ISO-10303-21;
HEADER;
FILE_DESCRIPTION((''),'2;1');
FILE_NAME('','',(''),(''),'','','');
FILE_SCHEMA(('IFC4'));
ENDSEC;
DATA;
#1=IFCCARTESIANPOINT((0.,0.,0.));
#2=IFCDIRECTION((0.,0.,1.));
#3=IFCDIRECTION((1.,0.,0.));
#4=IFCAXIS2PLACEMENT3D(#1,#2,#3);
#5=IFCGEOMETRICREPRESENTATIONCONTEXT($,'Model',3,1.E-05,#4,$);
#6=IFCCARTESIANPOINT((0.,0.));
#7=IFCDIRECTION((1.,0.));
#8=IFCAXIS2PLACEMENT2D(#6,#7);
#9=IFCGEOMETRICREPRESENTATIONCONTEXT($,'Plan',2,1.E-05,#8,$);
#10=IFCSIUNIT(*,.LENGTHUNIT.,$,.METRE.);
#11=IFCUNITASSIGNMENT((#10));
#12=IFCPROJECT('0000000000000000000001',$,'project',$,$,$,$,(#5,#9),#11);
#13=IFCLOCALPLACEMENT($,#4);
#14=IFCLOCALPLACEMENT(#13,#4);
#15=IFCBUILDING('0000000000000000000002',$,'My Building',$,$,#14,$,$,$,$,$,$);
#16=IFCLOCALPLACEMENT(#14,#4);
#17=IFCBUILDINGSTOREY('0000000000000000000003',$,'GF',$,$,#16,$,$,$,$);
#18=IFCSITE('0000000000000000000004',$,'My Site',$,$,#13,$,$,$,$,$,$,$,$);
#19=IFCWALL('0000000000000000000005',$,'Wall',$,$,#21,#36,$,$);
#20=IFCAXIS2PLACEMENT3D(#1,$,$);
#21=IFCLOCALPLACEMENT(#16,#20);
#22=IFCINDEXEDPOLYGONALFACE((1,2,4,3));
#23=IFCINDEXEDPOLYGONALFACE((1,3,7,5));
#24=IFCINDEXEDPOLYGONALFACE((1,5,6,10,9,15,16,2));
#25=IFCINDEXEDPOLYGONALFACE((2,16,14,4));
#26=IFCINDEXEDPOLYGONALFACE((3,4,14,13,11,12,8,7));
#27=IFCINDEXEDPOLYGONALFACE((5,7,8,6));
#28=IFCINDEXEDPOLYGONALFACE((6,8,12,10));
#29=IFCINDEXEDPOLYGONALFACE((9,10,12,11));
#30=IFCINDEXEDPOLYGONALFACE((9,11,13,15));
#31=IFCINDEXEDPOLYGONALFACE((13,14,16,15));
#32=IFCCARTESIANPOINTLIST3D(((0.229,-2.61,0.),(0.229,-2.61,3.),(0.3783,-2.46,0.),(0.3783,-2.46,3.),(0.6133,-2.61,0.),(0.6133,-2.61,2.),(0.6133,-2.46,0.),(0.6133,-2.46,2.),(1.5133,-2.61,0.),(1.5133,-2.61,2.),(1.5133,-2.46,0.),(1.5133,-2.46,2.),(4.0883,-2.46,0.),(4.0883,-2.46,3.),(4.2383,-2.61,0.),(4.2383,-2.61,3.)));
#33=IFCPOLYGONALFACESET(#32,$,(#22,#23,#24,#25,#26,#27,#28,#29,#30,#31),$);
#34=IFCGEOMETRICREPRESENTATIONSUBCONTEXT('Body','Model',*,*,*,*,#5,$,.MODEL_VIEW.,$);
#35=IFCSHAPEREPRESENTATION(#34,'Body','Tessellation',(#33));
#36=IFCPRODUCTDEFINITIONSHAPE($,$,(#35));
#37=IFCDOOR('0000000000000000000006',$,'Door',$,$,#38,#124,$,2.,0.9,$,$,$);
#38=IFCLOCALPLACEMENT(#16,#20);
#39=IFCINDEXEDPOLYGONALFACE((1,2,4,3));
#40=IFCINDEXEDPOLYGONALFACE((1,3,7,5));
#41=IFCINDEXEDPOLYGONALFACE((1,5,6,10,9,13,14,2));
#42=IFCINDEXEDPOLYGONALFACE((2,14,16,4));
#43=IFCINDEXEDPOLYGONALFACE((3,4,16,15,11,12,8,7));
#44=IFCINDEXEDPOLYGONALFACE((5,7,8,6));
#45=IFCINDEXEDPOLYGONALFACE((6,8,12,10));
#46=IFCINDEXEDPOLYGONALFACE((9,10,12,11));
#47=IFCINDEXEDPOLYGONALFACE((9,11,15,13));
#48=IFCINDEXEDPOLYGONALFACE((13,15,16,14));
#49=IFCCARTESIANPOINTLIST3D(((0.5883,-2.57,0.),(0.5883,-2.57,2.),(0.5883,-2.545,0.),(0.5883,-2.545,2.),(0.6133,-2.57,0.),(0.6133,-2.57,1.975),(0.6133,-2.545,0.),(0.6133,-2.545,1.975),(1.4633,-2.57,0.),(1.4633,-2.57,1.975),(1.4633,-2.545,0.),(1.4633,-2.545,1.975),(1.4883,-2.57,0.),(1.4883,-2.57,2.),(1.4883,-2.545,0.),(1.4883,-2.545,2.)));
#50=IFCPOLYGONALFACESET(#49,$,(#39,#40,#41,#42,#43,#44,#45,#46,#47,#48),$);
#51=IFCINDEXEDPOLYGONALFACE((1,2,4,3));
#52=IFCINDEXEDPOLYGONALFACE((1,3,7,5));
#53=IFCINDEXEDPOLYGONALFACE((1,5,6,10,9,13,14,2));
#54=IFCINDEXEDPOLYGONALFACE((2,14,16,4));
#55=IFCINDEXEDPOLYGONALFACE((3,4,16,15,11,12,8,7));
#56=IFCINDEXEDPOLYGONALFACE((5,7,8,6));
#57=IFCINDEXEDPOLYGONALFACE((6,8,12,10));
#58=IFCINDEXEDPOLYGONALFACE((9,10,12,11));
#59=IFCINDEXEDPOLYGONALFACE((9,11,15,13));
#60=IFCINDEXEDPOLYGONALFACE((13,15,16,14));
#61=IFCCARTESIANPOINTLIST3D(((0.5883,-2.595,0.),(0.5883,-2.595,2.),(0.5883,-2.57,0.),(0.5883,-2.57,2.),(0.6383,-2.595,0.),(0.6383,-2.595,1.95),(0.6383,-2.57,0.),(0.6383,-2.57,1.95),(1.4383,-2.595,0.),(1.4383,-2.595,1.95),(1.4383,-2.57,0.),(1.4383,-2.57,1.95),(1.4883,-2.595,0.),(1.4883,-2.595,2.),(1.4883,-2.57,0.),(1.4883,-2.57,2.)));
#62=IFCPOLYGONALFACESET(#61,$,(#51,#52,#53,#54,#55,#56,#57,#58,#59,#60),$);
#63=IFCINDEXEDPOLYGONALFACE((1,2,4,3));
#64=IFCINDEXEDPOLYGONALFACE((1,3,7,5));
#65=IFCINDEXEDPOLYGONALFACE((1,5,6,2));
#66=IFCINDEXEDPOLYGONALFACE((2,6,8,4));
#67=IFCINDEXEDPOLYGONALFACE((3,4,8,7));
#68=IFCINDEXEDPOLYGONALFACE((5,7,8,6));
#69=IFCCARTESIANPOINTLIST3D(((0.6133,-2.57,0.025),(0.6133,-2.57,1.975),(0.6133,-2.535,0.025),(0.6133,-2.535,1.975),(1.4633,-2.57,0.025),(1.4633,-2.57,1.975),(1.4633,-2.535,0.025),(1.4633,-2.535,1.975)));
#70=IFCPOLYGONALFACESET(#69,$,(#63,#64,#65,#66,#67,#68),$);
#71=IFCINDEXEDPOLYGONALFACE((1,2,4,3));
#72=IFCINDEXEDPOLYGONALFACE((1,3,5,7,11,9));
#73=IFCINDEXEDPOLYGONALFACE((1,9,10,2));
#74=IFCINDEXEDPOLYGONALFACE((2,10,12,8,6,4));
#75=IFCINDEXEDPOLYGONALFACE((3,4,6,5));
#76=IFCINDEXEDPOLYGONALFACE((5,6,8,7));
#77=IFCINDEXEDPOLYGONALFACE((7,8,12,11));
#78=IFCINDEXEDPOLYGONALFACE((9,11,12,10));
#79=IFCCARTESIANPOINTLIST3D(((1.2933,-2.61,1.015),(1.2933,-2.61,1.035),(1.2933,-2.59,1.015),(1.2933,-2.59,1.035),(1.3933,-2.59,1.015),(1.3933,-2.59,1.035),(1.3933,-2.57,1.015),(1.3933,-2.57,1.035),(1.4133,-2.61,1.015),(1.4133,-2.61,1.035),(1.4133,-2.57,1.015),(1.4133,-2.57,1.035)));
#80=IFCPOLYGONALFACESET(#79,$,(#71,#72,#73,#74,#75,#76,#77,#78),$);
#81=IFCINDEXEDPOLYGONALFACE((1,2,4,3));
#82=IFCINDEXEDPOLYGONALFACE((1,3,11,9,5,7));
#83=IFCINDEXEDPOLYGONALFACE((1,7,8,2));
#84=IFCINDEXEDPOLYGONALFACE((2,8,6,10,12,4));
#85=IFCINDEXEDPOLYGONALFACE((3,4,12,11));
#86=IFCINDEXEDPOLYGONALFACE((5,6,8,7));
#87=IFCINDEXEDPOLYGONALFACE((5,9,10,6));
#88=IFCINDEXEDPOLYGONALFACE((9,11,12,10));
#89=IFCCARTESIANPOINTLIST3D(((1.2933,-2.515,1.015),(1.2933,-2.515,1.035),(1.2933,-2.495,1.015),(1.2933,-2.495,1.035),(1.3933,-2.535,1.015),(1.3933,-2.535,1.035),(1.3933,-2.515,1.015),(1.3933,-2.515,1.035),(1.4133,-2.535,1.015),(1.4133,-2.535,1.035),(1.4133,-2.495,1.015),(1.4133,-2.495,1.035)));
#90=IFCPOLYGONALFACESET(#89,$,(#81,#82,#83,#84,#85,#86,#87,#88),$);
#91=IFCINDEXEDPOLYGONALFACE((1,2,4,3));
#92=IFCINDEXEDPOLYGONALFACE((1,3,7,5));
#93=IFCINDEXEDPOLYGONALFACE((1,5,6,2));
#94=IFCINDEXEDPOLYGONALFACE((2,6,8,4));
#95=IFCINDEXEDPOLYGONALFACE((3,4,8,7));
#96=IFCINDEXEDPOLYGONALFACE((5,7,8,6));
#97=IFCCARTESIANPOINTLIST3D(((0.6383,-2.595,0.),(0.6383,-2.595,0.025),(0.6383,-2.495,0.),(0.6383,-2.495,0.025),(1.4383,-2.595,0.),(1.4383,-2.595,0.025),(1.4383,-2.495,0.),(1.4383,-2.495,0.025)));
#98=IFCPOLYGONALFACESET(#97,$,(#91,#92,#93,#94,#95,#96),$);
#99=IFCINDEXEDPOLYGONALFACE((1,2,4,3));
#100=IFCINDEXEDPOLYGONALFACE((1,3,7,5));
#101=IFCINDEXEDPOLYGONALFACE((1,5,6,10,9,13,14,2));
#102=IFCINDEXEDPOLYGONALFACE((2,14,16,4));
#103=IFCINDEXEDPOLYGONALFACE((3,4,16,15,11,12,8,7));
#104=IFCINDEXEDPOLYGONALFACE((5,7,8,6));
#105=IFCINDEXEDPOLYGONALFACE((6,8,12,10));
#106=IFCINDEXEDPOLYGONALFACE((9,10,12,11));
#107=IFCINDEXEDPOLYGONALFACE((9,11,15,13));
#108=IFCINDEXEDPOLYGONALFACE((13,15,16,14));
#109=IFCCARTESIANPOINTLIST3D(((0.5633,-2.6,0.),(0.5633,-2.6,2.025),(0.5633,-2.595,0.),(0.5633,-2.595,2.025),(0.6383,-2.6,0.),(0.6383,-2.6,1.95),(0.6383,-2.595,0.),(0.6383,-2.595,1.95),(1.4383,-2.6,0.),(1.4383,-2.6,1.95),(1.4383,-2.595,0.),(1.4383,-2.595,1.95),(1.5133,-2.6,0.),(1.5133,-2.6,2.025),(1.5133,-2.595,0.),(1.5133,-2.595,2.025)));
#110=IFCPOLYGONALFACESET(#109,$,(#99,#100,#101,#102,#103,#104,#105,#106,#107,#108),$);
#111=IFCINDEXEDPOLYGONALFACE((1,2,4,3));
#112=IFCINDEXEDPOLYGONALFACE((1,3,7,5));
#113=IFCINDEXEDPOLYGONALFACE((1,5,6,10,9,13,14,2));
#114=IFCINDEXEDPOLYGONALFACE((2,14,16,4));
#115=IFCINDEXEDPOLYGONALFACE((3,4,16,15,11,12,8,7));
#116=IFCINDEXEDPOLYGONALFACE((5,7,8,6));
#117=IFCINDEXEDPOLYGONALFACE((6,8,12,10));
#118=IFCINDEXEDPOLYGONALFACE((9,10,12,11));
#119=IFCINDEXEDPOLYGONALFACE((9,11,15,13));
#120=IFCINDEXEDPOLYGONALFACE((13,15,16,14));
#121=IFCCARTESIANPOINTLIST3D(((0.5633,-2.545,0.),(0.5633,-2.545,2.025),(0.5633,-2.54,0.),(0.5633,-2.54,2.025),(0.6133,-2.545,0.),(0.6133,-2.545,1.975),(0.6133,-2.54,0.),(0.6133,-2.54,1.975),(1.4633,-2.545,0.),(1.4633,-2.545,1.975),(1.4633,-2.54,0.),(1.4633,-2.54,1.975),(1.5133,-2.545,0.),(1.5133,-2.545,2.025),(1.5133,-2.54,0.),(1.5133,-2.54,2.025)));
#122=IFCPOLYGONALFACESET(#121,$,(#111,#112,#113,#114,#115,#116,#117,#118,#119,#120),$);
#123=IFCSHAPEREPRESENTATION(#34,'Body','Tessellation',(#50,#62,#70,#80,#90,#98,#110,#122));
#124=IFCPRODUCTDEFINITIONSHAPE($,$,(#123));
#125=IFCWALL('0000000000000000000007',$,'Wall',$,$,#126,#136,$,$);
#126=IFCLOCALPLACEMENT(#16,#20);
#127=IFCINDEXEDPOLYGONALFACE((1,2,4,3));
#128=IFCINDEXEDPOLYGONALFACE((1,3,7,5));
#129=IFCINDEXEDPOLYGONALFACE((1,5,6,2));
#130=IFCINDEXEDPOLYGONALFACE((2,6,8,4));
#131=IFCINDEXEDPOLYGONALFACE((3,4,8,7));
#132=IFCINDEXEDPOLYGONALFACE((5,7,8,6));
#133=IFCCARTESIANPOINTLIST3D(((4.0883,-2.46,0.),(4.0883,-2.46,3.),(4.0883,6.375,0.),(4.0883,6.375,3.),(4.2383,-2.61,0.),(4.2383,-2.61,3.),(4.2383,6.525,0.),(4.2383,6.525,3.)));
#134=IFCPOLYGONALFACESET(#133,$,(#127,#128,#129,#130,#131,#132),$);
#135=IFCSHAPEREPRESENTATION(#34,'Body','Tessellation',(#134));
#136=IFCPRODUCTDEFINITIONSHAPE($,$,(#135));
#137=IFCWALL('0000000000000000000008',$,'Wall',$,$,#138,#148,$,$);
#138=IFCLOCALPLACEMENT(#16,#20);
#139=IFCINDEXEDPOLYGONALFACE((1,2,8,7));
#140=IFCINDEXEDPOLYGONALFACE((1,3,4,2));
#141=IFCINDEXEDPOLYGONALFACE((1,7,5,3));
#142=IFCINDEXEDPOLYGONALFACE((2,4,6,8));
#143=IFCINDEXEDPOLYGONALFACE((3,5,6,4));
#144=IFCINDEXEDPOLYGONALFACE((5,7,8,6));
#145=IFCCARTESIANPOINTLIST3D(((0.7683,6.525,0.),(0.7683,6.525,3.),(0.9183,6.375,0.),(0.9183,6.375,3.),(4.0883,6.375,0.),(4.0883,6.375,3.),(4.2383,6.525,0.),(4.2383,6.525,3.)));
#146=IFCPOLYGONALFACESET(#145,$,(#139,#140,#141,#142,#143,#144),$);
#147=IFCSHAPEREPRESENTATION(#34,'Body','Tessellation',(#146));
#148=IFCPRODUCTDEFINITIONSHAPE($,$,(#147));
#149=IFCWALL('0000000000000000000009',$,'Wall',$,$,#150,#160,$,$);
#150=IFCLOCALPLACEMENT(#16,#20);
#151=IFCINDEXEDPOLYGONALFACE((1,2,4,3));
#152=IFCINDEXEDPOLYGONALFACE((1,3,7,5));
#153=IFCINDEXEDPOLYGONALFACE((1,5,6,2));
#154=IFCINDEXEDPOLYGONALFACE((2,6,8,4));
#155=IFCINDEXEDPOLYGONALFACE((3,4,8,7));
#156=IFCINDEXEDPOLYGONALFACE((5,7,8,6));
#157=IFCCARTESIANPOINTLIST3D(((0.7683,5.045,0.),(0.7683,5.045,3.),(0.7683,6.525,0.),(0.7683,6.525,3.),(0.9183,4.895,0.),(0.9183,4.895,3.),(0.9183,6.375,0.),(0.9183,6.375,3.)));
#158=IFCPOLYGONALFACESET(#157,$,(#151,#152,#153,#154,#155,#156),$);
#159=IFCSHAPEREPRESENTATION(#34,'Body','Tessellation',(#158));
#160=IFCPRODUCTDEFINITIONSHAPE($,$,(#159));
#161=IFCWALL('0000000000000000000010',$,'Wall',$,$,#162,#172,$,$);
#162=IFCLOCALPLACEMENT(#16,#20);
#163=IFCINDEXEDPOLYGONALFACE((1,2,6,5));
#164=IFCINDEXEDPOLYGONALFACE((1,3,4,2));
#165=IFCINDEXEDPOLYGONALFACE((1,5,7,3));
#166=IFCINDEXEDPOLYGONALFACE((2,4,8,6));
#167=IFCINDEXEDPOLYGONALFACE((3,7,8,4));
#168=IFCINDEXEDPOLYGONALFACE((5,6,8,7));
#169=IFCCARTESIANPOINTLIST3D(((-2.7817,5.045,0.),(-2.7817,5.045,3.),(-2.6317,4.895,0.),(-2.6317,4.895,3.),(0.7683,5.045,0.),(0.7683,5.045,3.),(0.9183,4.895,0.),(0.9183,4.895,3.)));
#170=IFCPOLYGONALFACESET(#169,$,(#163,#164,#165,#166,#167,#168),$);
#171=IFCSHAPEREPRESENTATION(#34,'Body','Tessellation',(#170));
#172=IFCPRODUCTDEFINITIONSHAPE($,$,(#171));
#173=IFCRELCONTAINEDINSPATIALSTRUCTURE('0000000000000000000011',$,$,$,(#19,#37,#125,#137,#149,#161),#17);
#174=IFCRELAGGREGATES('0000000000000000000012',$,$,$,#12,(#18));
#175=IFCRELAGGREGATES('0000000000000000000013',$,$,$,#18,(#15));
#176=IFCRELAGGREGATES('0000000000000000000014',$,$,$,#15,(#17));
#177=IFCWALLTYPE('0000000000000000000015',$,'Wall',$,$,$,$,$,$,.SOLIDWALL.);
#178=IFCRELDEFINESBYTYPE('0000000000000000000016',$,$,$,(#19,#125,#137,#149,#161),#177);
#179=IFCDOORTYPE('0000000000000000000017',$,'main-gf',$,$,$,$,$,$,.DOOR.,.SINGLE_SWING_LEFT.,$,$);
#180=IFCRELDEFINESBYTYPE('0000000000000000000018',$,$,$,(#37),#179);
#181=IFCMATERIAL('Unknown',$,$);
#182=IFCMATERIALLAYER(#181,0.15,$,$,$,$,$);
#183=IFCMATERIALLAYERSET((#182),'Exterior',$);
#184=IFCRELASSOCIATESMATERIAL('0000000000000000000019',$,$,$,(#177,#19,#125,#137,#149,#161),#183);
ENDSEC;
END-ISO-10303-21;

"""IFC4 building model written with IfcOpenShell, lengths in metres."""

from ifc_helpers import new_model, entity, si_unit, frame, origin_with_axes, origin_2d_with_axis, place, context, subcontext, project, spatial, line, indexed_curve, outline, extrude, shape, source, transform, mapped, material, layer, layer_set, layer_usage, type_object, type_shapes, element, fill, save


model = new_model("IFC4")

# Units and contexts
model_context = context("Model", 3, precision=1e-05, world=origin_with_axes())
plan_context = context("Plan", 2, precision=1e-05, world=origin_2d_with_axis())
body_context_1 = subcontext(model_context, "Body", "Model", "MODEL_VIEW")
body_context_2 = subcontext(plan_context, "Body", "Plan", "PLAN_VIEW")
ifc_project = project(units=[si_unit("LENGTHUNIT", "METRE")], contexts=[model_context, plan_context])

# Site, building, storey
site_placement = place(None, origin_with_axes())
site = spatial("IfcSite", under=ifc_project, at=site_placement, Name="My Site")
building_placement = place(site_placement, origin_with_axes())
building = spatial("IfcBuilding", under=site, at=building_placement, Name="My Building")
storey_placement = place(building_placement, origin_with_axes())
storey = spatial("IfcBuildingStorey", under=building, at=storey_placement, Name="GF")

# Wall, opening, door
ifc_material = material(Name="Unknown")
ifc_layer_1 = layer(ifc_material, 0.15)
ifc_layer_set_1 = layer_set([ifc_layer_1], Name="Exterior")
ifc_layer_usage_1 = layer_usage(ifc_layer_set_1, "AXIS2", "POSITIVE", 0.0)
wall_type_1 = type_object("IfcWallType", Name="Wall", PredefinedType="SOLIDWALL", material=ifc_layer_set_1)
wall_1_placement = place(storey_placement, frame((0.229, -2.61, 0.0), z_axis=(0.0, 0.0, 1.0), x_axis=(1.0, 0.0, 0.0)))
wall_1 = element("IfcWall", 1, at=wall_1_placement, inside=storey, type_object=wall_type_1, material=ifc_layer_usage_1, Name="Wall", context=body_context_1, shape_type="SweptSolid", body=[
    extrude(outline(indexed_curve([(0.0, 0.0), (0.1494, 0.15), (3.8594, 0.15), (4.0094, 0.0)], segments=[line(1, 2, 3, 4, 1)])), origin_with_axes(), (0.0, 0.0, 1.0), 3.0),
])
shared_shape_1 = source(origin_with_axes(), body_context_1, "Body", "SweptSolid", [
    extrude(outline(indexed_curve([(0.0, 0.0), (0.9, 0.0), (0.9, 2.0), (0.0, 2.0)], segments=[line(1, 2, 3, 4, 1)])), frame((0.0, -0.6, 0.0), z_axis=(0.0, -1.0, 0.0), x_axis=(1.0, 0.0, 0.0)), (0.0, 0.0, -1.0), 1.2),
])
opening_placement = place(wall_1_placement, frame((1.2843, 0.15, 0.0), z_axis=(0.0, 0.0, 1.0), x_axis=(-1.0, 0.0, 0.0)))
opening = element("IfcOpeningElement", 2, at=opening_placement, cuts=wall_1, PredefinedType="OPENING", context=body_context_1, shape_type="MappedRepresentation", body=[
    mapped(shared_shape_1, transform((0.0, 0.0, 0.0), x_axis=(1.0, 0.0, 0.0), y_axis=(0.0, 1.0, 0.0), z_axis=(0.0, 0.0, 1.0), scale=1.0)),
])
door_type = type_object("IfcDoorType", Name="main-gf", OperationType="SINGLE_SWING_LEFT", PredefinedType="DOOR")
shared_shape_2 = source(origin_with_axes(), body_context_1, "Body", "SweptSolid", [
    extrude(outline(indexed_curve([(0.0, 0.0), (0.0, 2.0), (0.9, 2.0), (0.9, 0.0), (0.875, 0.0), (0.875, 1.975), (0.025, 1.975), (0.025, 0.0)], segments=[line(1, 2, 3, 4, 5, 6, 7, 8, 1)])), frame((0.0, 0.025, 0.0), z_axis=(0.0, -1.0, 0.0), x_axis=(1.0, 0.0, 0.0)), (0.0, 0.0, -1.0), 0.025),
    extrude(outline(indexed_curve([(0.0, 0.0), (0.0, 2.0), (0.9, 2.0), (0.9, 0.0), (0.85, 0.0), (0.85, 1.95), (0.05, 1.95), (0.05, 0.0)], segments=[line(1, 2, 3, 4, 5, 6, 7, 8, 1)])), frame((0.0, 0.0, 0.0), z_axis=(0.0, -1.0, 0.0), x_axis=(1.0, 0.0, 0.0)), (0.0, 0.0, -1.0), 0.025),
    extrude(outline(indexed_curve([(0.0, 0.0), (0.85, 0.0), (0.85, 0.035), (0.0, 0.035)], segments=[line(1, 2, 3, 4, 1)])), frame((0.025, 0.025, 0.025), z_axis=(0.0, 0.0, 1.0), x_axis=(1.0, 0.0, 0.0)), (0.0, 0.0, 1.0), 1.95),
    extrude(outline(indexed_curve([(0.0, 0.0), (0.0, -0.04), (-0.12, -0.04), (-0.12, -0.02), (-0.02, -0.02), (-0.02, 0.0)], segments=[line(1, 2, 3, 4, 5, 6, 1)])), frame((0.825, 0.025, 1.015), z_axis=(0.0, 0.0, 1.0), x_axis=(1.0, 0.0, 0.0)), (0.0, 0.0, 1.0), 0.02),
    extrude(outline(indexed_curve([(0.0, 0.0), (0.0, 0.04), (-0.12, 0.04), (-0.12, 0.02), (-0.02, 0.02), (-0.02, 0.0)], segments=[line(1, 2, 3, 4, 5, 6, 1)])), frame((0.825, 0.06, 1.015), z_axis=(0.0, 0.0, 1.0), x_axis=(1.0, 0.0, 0.0)), (0.0, 0.0, 1.0), 0.02),
    extrude(outline(indexed_curve([(0.0, 0.0), (0.8, 0.0), (0.8, 0.1), (0.0, 0.1)], segments=[line(1, 2, 3, 4, 1)])), frame((0.05, 0.0, 0.0), z_axis=(0.0, 0.0, 1.0), x_axis=(1.0, 0.0, 0.0)), (0.0, 0.0, 1.0), 0.025),
    extrude(outline(indexed_curve([(0.0, 0.0), (0.0, 2.025), (0.95, 2.025), (0.95, 0.0), (0.875, 0.0), (0.875, 1.95), (0.075, 1.95), (0.075, 0.0)], segments=[line(1, 2, 3, 4, 5, 6, 7, 8, 1)])), frame((-0.025, -0.005, 0.0), z_axis=(0.0, -1.0, 0.0), x_axis=(1.0, 0.0, 0.0)), (0.0, 0.0, -1.0), 0.005),
    extrude(outline(indexed_curve([(0.0, 0.0), (0.0, 2.025), (0.95, 2.025), (0.95, 0.0), (0.9, 0.0), (0.9, 1.975), (0.05, 1.975), (0.05, 0.0)], segments=[line(1, 2, 3, 4, 5, 6, 7, 8, 1)])), frame((-0.025, 0.05, 0.0), z_axis=(0.0, -1.0, 0.0), x_axis=(1.0, 0.0, 0.0)), (0.0, 0.0, -1.0), 0.005),
])
shared_shape_3 = source(origin_with_axes(), body_context_2, "Body", "Curve2D", [
    entity("IfcIndexedPolyCurve", entity("IfcCartesianPointList2D", [[0.0, 0.0], [0.0, 0.05], [0.025, 0.05], [0.025, 0.025], [0.05, 0.025], [0.05, 0.0]]), [entity("IfcLineIndex", [1, 2, 3, 4, 5, 6, 1])]),
    entity("IfcIndexedPolyCurve", entity("IfcCartesianPointList2D", [[0.9, 0.0], [0.9, 0.05], [0.875, 0.05], [0.875, 0.025], [0.85, 0.025], [0.85, 0.0]]), [entity("IfcLineIndex", [1, 2, 3, 4, 5, 6, 1])]),
    entity("IfcTrimmedCurve", entity("IfcEllipse", entity("IfcAxis2Placement2D", entity("IfcCartesianPoint", [0.06, 0.05]), entity("IfcDirection", [1.0, 0.0])), 0.815, 0.85), [entity("IfcCartesianPoint", [0.875, 0.05])], [entity("IfcCartesianPoint", [0.06, 0.9])], True, "CARTESIAN"),
    entity("IfcIndexedPolyCurve", entity("IfcCartesianPointList2D", [[0.025, 0.05], [0.06, 0.05], [0.06, 0.9], [0.025, 0.9]]), [entity("IfcLineIndex", [1, 2, 3, 4, 1])]),
])
type_shapes(door_type, [shared_shape_2, shared_shape_3])
door_placement = place(opening_placement, frame((0.925, 0.135, 0.0), z_axis=(0.0, 0.0, 1.0), x_axis=(-1.0, 0.000001, 0.0)))
door = element("IfcDoor", 3, at=door_placement, inside=storey, type_object=door_type, Name="Door", OverallHeight=2.0, OverallWidth=0.9, shapes=[
    shape(body_context_1, "Body", "MappedRepresentation", [mapped(shared_shape_2, transform((0.0, 0.0, 0.0), x_axis=(1.0, 0.0, 0.0), y_axis=(0.0, 1.0, 0.0), z_axis=(0.0, 0.0, 1.0), scale=1.0))]),
    shape(body_context_2, "Body", "MappedRepresentation", [mapped(shared_shape_3, transform((0.0, 0.0, 0.0), x_axis=(1.0, 0.0, 0.0), y_axis=(0.0, 1.0, 0.0), z_axis=(0.0, 0.0, 1.0), scale=1.0))]),
])
fill(opening, door)

# Walls
ifc_layer_usage_2 = layer_usage(ifc_layer_set_1, "AXIS2", "POSITIVE", 0.0)
wall_2_placement = place(storey_placement, frame((4.2383, -2.61, 0.0), z_axis=(0.0, 0.0, 1.0), x_axis=(0.0, 1.0, 0.0)))
element("IfcWall", 4, at=wall_2_placement, inside=storey, type_object=wall_type_1, material=ifc_layer_usage_2, Name="Wall", context=body_context_1, shape_type="SweptSolid", body=[
    extrude(outline(indexed_curve([(0.0, 0.0), (0.15, 0.15), (8.985, 0.15), (9.135, 0.0)], segments=[line(1, 2, 3, 4, 1)])), origin_with_axes(), (0.0, 0.0, 1.0), 3.0),
])
ifc_layer_usage_3 = layer_usage(ifc_layer_set_1, "AXIS2", "POSITIVE", 0.0)
wall_3_placement = place(storey_placement, frame((4.2383, 6.525, 0.0), z_axis=(0.0, 0.0, 1.0), x_axis=(-1.0, 0.0, 0.0)))
element("IfcWall", 5, at=wall_3_placement, inside=storey, type_object=wall_type_1, material=ifc_layer_usage_3, Name="Wall", context=body_context_1, shape_type="SweptSolid", body=[
    extrude(outline(indexed_curve([(0.0, 0.0), (0.15, 0.15), (3.32, 0.15), (3.47, 0.0)], segments=[line(1, 2, 3, 4, 1)])), origin_with_axes(), (0.0, 0.0, 1.0), 3.0),
])
ifc_layer_usage_4 = layer_usage(ifc_layer_set_1, "AXIS2", "POSITIVE", 0.0)
wall_4_placement = place(storey_placement, frame((0.7683, 6.525, 0.0), z_axis=(0.0, 0.0, 1.0), x_axis=(0.0, -1.0, 0.0)))
element("IfcWall", 6, at=wall_4_placement, inside=storey, type_object=wall_type_1, material=ifc_layer_usage_4, Name="Wall", context=body_context_1, shape_type="SweptSolid", body=[
    extrude(outline(indexed_curve([(0.0, 0.0), (0.15, 0.15), (1.63, 0.15), (1.48, 0.0)], segments=[line(1, 2, 3, 4, 1)])), origin_with_axes(), (0.0, 0.0, 1.0), 3.0),
])
ifc_layer_usage_5 = layer_usage(ifc_layer_set_1, "AXIS2", "POSITIVE", 0.0)
wall_5_placement = place(storey_placement, frame((0.7683, 5.045, 0.0), z_axis=(0.0, 0.0, 1.0), x_axis=(-1.0, 0.0, 0.0)))
element("IfcWall", 7, at=wall_5_placement, inside=storey, type_object=wall_type_1, material=ifc_layer_usage_5, Name="Wall", context=body_context_1, shape_type="SweptSolid", body=[
    extrude(outline(indexed_curve([(0.0, 0.0), (-0.15, 0.15), (3.4, 0.15), (3.55, 0.0)], segments=[line(1, 2, 3, 4, 1)])), origin_with_axes(), (0.0, 0.0, 1.0), 3.0),
])

save(model, "model.ifc")
